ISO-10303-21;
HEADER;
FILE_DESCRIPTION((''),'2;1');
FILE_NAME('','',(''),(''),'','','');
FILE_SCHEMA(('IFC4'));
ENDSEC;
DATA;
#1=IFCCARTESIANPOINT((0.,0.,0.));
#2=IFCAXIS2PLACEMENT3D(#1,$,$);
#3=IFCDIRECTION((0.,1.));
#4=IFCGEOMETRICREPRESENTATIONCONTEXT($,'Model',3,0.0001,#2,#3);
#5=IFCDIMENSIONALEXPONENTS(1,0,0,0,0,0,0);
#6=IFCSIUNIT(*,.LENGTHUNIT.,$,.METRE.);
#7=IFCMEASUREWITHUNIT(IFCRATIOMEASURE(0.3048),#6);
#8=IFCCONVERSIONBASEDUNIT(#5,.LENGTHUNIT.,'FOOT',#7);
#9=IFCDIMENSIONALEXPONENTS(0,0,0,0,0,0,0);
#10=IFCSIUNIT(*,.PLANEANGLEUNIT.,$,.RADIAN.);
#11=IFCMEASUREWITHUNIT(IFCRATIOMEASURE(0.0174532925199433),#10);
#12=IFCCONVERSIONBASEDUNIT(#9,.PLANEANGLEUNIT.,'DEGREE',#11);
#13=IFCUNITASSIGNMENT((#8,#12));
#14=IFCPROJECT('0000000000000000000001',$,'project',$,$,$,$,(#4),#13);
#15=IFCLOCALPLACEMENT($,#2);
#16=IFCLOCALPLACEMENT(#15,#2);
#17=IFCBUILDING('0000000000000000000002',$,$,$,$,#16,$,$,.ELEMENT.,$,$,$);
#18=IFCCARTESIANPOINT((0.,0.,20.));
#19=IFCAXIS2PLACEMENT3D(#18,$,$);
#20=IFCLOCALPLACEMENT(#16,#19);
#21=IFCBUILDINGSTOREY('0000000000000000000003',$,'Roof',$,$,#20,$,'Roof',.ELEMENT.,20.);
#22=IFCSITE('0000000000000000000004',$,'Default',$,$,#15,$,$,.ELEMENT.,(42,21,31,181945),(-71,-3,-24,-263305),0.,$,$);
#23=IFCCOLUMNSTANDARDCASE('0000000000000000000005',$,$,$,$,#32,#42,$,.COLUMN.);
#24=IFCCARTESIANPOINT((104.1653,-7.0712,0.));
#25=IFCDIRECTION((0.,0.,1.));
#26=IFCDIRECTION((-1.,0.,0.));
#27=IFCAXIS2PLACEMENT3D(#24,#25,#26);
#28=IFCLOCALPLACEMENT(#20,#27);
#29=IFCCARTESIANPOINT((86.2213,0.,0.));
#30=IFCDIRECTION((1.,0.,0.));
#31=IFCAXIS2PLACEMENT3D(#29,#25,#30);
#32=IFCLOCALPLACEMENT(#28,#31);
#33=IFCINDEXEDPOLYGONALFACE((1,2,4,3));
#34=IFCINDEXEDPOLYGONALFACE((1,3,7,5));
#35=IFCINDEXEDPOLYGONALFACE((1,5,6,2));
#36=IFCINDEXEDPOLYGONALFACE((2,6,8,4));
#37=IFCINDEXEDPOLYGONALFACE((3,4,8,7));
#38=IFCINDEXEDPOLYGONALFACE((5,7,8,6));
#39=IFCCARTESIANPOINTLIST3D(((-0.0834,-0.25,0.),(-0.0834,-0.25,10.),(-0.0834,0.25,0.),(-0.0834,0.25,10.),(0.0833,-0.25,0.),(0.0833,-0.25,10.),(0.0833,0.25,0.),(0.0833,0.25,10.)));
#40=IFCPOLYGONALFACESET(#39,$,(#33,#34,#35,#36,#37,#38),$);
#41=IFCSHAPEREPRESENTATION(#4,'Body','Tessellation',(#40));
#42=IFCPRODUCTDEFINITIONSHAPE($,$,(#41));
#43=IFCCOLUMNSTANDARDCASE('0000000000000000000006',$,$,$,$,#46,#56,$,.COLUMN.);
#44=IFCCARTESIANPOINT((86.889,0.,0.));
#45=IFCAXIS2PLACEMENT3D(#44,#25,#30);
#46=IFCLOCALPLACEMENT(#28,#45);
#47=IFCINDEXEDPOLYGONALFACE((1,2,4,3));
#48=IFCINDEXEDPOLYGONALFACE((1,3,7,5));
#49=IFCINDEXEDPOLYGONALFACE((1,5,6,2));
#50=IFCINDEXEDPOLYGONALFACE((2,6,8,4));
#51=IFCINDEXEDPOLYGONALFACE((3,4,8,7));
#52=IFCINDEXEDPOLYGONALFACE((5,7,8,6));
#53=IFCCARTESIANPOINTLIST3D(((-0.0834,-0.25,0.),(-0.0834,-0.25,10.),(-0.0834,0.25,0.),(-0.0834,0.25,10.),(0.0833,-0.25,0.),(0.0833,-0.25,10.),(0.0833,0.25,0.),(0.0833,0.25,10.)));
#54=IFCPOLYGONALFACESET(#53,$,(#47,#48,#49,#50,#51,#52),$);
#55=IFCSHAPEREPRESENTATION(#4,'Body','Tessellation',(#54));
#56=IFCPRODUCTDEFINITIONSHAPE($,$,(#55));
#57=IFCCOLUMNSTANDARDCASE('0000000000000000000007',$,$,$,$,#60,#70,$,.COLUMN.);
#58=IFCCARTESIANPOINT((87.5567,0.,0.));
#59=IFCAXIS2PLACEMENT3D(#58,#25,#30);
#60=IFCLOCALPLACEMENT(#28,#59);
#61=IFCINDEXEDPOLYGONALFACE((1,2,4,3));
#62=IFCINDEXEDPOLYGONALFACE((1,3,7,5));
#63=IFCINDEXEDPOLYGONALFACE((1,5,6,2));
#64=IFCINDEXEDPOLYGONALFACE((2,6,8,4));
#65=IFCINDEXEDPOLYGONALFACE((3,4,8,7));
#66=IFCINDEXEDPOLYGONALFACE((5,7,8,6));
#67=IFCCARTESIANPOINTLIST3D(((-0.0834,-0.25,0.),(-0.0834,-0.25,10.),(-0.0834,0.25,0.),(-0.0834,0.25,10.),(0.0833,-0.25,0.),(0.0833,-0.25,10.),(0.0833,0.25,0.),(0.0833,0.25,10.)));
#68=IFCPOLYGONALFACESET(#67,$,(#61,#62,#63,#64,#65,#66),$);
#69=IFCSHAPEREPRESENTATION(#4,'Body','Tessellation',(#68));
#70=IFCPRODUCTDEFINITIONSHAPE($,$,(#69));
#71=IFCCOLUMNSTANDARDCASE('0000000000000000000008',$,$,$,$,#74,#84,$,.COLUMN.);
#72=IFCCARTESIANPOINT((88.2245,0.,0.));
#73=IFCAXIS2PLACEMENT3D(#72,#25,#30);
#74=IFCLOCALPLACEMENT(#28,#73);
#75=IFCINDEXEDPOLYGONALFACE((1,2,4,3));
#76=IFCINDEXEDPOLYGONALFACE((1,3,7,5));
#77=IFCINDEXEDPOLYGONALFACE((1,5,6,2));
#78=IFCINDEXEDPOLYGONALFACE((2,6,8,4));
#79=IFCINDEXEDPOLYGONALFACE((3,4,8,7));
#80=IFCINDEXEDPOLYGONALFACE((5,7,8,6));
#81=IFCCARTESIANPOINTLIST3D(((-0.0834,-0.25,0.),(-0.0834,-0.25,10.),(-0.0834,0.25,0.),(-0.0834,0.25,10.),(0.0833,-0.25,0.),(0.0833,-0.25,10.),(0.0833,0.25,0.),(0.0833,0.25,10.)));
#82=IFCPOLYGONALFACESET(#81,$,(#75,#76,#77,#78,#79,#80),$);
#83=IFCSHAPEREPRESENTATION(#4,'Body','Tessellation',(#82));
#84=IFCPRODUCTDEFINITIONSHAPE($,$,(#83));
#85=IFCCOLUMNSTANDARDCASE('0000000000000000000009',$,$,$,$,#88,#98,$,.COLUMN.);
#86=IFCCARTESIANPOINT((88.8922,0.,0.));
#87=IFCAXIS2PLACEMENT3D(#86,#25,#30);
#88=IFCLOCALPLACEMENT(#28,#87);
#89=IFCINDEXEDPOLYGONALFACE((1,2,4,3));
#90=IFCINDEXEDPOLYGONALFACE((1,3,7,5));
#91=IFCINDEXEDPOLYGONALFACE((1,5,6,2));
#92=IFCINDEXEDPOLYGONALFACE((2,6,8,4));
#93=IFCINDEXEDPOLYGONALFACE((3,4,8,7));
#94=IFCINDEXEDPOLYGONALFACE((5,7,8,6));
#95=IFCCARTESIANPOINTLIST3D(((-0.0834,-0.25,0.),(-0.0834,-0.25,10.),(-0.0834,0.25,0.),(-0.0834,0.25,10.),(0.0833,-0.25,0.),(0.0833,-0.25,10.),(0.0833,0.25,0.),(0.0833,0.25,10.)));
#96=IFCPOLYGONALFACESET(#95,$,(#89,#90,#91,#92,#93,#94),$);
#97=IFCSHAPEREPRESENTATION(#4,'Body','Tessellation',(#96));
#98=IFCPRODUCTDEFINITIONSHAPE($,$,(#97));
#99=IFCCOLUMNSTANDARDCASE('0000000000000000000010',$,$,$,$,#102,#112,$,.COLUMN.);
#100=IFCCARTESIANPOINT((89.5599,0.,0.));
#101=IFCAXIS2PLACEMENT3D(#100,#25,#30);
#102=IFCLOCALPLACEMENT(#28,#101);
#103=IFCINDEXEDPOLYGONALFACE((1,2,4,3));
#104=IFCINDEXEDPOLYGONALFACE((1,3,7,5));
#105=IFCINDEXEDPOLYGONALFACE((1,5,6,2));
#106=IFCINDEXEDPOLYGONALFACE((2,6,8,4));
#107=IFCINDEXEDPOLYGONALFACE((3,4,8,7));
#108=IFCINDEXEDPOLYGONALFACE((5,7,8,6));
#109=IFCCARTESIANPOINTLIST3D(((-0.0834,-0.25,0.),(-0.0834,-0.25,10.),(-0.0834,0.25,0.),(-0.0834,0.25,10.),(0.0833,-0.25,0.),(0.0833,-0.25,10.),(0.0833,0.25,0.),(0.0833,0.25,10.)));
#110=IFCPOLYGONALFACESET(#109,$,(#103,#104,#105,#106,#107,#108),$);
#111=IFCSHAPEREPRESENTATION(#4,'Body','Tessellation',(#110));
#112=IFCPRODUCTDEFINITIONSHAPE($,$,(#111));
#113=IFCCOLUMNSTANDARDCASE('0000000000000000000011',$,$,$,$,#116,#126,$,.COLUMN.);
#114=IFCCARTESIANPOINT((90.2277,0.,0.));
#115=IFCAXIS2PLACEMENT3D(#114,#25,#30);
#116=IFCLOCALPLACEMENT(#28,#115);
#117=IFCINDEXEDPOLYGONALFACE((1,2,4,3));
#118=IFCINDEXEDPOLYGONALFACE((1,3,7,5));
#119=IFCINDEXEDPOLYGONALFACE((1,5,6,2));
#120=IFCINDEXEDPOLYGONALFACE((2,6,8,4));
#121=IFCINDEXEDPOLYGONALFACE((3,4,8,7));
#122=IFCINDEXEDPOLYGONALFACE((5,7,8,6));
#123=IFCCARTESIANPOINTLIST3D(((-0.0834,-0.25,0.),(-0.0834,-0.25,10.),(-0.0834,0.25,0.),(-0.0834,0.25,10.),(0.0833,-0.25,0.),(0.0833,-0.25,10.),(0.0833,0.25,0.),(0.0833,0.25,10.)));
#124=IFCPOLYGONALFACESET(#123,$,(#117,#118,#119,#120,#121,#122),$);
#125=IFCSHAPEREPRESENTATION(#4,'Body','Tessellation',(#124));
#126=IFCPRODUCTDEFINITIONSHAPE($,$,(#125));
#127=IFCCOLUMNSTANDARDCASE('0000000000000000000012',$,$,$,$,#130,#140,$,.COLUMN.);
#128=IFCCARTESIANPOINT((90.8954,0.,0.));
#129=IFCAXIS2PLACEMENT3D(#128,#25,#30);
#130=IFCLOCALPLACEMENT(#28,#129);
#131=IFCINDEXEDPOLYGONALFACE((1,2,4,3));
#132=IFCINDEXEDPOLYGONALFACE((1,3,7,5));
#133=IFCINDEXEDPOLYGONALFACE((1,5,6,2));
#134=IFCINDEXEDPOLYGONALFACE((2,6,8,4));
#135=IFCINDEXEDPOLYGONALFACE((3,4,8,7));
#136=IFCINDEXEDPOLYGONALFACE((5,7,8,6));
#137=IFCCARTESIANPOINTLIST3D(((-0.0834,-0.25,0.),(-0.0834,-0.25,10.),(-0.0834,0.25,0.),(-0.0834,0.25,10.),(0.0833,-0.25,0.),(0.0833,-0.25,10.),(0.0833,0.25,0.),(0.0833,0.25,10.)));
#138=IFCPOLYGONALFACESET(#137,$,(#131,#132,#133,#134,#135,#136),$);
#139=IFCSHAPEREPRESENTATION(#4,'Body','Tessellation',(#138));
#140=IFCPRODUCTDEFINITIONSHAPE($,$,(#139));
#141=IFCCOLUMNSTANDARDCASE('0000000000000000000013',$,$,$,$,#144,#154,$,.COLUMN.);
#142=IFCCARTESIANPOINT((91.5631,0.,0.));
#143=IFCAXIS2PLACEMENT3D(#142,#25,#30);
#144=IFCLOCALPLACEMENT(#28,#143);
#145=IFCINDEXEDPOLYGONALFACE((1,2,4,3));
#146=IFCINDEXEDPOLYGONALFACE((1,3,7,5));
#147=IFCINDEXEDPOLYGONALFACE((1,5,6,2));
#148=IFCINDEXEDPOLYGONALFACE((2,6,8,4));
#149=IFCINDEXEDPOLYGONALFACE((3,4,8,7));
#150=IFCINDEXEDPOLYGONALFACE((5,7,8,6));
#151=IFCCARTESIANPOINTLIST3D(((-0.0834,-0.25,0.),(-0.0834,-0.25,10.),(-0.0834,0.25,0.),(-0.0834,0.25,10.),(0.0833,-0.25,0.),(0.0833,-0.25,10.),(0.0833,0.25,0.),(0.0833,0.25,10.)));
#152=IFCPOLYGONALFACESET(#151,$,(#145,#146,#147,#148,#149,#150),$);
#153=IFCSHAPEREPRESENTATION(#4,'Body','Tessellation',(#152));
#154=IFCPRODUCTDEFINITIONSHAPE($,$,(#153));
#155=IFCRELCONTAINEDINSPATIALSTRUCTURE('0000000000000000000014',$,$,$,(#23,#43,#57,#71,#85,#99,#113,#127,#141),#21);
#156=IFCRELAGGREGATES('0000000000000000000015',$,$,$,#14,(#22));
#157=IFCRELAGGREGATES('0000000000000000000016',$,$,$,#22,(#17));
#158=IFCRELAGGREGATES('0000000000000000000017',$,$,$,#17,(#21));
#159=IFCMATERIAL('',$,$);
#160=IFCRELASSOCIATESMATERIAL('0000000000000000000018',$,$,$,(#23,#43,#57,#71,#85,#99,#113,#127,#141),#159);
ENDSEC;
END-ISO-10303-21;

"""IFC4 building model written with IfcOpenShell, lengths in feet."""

from ifc_helpers import new_model, entity, si_unit, converted_unit, direction, frame, origin, place, context, project, spatial, rectangle, extrude, material, element, save


model = new_model("IFC4")

# Units and contexts
model_context = context("Model", 3, precision=0.0001, world=origin(), true_north=direction((0.0, 1.0)))
ifc_project = project(units=[converted_unit("LENGTHUNIT", "FOOT", entity("IfcRatioMeasure", 0.3048), si_unit("LENGTHUNIT", "METRE"), dimensions=[1, 0, 0, 0, 0, 0, 0]), converted_unit("PLANEANGLEUNIT", "DEGREE", entity("IfcRatioMeasure", 0.0174532925199433), si_unit("PLANEANGLEUNIT", "RADIAN"), dimensions=[0, 0, 0, 0, 0, 0, 0])], contexts=[model_context])

# Site, building, storey
site_placement = place(None, origin())
site = spatial("IfcSite", under=ifc_project, at=site_placement, Name="Default", CompositionType="ELEMENT", RefLatitude=(42, 21, 31, 181945), RefLongitude=(-71, -3, -24, -263305), RefElevation=0.0)
building_placement = place(site_placement, origin())
building = spatial("IfcBuilding", under=site, at=building_placement, CompositionType="ELEMENT")
storey_placement = place(building_placement, frame((0.0, 0.0, 20.0)))
storey = spatial("IfcBuildingStorey", under=building, at=storey_placement, Name="Roof", LongName="Roof", CompositionType="ELEMENT", Elevation=20.0)

# Columns
ifc_material_1 = material(Name="")
placement_1 = place(storey_placement, frame((104.1653, -7.0712, 0.0), z_axis=(0.0, 0.0, 1.0), x_axis=(-1.0, 0.0, 0.0)))
for number, where, z_axis, x_axis in (
    (1, (86.2213, 0.0, 0.0), (0.0, 0.0, 1.0), (1.0, 0.0, 0.0)),
    (2, (86.889, 0.0, 0.0), (0.0, 0.0, 1.0), (1.0, 0.0, 0.0)),
    (3, (87.5567, 0.0, 0.0), (0.0, 0.0, 1.0), (1.0, 0.0, 0.0)),
    (4, (88.2245, 0.0, 0.0), (0.0, 0.0, 1.0), (1.0, 0.0, 0.0)),
    (5, (88.8922, 0.0, 0.0), (0.0, 0.0, 1.0), (1.0, 0.0, 0.0)),
    (6, (89.5599, 0.0, 0.0), (0.0, 0.0, 1.0), (1.0, 0.0, 0.0)),
    (7, (90.2277, 0.0, 0.0), (0.0, 0.0, 1.0), (1.0, 0.0, 0.0)),
    (8, (90.8954, 0.0, 0.0), (0.0, 0.0, 1.0), (1.0, 0.0, 0.0)),
    (9, (91.5631, 0.0, 0.0), (0.0, 0.0, 1.0), (1.0, 0.0, 0.0)),
):
    element("IfcColumnStandardCase", number, at=place(placement_1, frame(where, z_axis=z_axis, x_axis=x_axis)), inside=storey, material=ifc_material_1, PredefinedType="COLUMN", context=model_context, shape_type="SweptSolid", body=[
        extrude(rectangle(XDim=0.1667, YDim=0.5), origin(), (0.0, 0.0, 1.0), 10.0),
    ])

save(model, "model.ifc")
